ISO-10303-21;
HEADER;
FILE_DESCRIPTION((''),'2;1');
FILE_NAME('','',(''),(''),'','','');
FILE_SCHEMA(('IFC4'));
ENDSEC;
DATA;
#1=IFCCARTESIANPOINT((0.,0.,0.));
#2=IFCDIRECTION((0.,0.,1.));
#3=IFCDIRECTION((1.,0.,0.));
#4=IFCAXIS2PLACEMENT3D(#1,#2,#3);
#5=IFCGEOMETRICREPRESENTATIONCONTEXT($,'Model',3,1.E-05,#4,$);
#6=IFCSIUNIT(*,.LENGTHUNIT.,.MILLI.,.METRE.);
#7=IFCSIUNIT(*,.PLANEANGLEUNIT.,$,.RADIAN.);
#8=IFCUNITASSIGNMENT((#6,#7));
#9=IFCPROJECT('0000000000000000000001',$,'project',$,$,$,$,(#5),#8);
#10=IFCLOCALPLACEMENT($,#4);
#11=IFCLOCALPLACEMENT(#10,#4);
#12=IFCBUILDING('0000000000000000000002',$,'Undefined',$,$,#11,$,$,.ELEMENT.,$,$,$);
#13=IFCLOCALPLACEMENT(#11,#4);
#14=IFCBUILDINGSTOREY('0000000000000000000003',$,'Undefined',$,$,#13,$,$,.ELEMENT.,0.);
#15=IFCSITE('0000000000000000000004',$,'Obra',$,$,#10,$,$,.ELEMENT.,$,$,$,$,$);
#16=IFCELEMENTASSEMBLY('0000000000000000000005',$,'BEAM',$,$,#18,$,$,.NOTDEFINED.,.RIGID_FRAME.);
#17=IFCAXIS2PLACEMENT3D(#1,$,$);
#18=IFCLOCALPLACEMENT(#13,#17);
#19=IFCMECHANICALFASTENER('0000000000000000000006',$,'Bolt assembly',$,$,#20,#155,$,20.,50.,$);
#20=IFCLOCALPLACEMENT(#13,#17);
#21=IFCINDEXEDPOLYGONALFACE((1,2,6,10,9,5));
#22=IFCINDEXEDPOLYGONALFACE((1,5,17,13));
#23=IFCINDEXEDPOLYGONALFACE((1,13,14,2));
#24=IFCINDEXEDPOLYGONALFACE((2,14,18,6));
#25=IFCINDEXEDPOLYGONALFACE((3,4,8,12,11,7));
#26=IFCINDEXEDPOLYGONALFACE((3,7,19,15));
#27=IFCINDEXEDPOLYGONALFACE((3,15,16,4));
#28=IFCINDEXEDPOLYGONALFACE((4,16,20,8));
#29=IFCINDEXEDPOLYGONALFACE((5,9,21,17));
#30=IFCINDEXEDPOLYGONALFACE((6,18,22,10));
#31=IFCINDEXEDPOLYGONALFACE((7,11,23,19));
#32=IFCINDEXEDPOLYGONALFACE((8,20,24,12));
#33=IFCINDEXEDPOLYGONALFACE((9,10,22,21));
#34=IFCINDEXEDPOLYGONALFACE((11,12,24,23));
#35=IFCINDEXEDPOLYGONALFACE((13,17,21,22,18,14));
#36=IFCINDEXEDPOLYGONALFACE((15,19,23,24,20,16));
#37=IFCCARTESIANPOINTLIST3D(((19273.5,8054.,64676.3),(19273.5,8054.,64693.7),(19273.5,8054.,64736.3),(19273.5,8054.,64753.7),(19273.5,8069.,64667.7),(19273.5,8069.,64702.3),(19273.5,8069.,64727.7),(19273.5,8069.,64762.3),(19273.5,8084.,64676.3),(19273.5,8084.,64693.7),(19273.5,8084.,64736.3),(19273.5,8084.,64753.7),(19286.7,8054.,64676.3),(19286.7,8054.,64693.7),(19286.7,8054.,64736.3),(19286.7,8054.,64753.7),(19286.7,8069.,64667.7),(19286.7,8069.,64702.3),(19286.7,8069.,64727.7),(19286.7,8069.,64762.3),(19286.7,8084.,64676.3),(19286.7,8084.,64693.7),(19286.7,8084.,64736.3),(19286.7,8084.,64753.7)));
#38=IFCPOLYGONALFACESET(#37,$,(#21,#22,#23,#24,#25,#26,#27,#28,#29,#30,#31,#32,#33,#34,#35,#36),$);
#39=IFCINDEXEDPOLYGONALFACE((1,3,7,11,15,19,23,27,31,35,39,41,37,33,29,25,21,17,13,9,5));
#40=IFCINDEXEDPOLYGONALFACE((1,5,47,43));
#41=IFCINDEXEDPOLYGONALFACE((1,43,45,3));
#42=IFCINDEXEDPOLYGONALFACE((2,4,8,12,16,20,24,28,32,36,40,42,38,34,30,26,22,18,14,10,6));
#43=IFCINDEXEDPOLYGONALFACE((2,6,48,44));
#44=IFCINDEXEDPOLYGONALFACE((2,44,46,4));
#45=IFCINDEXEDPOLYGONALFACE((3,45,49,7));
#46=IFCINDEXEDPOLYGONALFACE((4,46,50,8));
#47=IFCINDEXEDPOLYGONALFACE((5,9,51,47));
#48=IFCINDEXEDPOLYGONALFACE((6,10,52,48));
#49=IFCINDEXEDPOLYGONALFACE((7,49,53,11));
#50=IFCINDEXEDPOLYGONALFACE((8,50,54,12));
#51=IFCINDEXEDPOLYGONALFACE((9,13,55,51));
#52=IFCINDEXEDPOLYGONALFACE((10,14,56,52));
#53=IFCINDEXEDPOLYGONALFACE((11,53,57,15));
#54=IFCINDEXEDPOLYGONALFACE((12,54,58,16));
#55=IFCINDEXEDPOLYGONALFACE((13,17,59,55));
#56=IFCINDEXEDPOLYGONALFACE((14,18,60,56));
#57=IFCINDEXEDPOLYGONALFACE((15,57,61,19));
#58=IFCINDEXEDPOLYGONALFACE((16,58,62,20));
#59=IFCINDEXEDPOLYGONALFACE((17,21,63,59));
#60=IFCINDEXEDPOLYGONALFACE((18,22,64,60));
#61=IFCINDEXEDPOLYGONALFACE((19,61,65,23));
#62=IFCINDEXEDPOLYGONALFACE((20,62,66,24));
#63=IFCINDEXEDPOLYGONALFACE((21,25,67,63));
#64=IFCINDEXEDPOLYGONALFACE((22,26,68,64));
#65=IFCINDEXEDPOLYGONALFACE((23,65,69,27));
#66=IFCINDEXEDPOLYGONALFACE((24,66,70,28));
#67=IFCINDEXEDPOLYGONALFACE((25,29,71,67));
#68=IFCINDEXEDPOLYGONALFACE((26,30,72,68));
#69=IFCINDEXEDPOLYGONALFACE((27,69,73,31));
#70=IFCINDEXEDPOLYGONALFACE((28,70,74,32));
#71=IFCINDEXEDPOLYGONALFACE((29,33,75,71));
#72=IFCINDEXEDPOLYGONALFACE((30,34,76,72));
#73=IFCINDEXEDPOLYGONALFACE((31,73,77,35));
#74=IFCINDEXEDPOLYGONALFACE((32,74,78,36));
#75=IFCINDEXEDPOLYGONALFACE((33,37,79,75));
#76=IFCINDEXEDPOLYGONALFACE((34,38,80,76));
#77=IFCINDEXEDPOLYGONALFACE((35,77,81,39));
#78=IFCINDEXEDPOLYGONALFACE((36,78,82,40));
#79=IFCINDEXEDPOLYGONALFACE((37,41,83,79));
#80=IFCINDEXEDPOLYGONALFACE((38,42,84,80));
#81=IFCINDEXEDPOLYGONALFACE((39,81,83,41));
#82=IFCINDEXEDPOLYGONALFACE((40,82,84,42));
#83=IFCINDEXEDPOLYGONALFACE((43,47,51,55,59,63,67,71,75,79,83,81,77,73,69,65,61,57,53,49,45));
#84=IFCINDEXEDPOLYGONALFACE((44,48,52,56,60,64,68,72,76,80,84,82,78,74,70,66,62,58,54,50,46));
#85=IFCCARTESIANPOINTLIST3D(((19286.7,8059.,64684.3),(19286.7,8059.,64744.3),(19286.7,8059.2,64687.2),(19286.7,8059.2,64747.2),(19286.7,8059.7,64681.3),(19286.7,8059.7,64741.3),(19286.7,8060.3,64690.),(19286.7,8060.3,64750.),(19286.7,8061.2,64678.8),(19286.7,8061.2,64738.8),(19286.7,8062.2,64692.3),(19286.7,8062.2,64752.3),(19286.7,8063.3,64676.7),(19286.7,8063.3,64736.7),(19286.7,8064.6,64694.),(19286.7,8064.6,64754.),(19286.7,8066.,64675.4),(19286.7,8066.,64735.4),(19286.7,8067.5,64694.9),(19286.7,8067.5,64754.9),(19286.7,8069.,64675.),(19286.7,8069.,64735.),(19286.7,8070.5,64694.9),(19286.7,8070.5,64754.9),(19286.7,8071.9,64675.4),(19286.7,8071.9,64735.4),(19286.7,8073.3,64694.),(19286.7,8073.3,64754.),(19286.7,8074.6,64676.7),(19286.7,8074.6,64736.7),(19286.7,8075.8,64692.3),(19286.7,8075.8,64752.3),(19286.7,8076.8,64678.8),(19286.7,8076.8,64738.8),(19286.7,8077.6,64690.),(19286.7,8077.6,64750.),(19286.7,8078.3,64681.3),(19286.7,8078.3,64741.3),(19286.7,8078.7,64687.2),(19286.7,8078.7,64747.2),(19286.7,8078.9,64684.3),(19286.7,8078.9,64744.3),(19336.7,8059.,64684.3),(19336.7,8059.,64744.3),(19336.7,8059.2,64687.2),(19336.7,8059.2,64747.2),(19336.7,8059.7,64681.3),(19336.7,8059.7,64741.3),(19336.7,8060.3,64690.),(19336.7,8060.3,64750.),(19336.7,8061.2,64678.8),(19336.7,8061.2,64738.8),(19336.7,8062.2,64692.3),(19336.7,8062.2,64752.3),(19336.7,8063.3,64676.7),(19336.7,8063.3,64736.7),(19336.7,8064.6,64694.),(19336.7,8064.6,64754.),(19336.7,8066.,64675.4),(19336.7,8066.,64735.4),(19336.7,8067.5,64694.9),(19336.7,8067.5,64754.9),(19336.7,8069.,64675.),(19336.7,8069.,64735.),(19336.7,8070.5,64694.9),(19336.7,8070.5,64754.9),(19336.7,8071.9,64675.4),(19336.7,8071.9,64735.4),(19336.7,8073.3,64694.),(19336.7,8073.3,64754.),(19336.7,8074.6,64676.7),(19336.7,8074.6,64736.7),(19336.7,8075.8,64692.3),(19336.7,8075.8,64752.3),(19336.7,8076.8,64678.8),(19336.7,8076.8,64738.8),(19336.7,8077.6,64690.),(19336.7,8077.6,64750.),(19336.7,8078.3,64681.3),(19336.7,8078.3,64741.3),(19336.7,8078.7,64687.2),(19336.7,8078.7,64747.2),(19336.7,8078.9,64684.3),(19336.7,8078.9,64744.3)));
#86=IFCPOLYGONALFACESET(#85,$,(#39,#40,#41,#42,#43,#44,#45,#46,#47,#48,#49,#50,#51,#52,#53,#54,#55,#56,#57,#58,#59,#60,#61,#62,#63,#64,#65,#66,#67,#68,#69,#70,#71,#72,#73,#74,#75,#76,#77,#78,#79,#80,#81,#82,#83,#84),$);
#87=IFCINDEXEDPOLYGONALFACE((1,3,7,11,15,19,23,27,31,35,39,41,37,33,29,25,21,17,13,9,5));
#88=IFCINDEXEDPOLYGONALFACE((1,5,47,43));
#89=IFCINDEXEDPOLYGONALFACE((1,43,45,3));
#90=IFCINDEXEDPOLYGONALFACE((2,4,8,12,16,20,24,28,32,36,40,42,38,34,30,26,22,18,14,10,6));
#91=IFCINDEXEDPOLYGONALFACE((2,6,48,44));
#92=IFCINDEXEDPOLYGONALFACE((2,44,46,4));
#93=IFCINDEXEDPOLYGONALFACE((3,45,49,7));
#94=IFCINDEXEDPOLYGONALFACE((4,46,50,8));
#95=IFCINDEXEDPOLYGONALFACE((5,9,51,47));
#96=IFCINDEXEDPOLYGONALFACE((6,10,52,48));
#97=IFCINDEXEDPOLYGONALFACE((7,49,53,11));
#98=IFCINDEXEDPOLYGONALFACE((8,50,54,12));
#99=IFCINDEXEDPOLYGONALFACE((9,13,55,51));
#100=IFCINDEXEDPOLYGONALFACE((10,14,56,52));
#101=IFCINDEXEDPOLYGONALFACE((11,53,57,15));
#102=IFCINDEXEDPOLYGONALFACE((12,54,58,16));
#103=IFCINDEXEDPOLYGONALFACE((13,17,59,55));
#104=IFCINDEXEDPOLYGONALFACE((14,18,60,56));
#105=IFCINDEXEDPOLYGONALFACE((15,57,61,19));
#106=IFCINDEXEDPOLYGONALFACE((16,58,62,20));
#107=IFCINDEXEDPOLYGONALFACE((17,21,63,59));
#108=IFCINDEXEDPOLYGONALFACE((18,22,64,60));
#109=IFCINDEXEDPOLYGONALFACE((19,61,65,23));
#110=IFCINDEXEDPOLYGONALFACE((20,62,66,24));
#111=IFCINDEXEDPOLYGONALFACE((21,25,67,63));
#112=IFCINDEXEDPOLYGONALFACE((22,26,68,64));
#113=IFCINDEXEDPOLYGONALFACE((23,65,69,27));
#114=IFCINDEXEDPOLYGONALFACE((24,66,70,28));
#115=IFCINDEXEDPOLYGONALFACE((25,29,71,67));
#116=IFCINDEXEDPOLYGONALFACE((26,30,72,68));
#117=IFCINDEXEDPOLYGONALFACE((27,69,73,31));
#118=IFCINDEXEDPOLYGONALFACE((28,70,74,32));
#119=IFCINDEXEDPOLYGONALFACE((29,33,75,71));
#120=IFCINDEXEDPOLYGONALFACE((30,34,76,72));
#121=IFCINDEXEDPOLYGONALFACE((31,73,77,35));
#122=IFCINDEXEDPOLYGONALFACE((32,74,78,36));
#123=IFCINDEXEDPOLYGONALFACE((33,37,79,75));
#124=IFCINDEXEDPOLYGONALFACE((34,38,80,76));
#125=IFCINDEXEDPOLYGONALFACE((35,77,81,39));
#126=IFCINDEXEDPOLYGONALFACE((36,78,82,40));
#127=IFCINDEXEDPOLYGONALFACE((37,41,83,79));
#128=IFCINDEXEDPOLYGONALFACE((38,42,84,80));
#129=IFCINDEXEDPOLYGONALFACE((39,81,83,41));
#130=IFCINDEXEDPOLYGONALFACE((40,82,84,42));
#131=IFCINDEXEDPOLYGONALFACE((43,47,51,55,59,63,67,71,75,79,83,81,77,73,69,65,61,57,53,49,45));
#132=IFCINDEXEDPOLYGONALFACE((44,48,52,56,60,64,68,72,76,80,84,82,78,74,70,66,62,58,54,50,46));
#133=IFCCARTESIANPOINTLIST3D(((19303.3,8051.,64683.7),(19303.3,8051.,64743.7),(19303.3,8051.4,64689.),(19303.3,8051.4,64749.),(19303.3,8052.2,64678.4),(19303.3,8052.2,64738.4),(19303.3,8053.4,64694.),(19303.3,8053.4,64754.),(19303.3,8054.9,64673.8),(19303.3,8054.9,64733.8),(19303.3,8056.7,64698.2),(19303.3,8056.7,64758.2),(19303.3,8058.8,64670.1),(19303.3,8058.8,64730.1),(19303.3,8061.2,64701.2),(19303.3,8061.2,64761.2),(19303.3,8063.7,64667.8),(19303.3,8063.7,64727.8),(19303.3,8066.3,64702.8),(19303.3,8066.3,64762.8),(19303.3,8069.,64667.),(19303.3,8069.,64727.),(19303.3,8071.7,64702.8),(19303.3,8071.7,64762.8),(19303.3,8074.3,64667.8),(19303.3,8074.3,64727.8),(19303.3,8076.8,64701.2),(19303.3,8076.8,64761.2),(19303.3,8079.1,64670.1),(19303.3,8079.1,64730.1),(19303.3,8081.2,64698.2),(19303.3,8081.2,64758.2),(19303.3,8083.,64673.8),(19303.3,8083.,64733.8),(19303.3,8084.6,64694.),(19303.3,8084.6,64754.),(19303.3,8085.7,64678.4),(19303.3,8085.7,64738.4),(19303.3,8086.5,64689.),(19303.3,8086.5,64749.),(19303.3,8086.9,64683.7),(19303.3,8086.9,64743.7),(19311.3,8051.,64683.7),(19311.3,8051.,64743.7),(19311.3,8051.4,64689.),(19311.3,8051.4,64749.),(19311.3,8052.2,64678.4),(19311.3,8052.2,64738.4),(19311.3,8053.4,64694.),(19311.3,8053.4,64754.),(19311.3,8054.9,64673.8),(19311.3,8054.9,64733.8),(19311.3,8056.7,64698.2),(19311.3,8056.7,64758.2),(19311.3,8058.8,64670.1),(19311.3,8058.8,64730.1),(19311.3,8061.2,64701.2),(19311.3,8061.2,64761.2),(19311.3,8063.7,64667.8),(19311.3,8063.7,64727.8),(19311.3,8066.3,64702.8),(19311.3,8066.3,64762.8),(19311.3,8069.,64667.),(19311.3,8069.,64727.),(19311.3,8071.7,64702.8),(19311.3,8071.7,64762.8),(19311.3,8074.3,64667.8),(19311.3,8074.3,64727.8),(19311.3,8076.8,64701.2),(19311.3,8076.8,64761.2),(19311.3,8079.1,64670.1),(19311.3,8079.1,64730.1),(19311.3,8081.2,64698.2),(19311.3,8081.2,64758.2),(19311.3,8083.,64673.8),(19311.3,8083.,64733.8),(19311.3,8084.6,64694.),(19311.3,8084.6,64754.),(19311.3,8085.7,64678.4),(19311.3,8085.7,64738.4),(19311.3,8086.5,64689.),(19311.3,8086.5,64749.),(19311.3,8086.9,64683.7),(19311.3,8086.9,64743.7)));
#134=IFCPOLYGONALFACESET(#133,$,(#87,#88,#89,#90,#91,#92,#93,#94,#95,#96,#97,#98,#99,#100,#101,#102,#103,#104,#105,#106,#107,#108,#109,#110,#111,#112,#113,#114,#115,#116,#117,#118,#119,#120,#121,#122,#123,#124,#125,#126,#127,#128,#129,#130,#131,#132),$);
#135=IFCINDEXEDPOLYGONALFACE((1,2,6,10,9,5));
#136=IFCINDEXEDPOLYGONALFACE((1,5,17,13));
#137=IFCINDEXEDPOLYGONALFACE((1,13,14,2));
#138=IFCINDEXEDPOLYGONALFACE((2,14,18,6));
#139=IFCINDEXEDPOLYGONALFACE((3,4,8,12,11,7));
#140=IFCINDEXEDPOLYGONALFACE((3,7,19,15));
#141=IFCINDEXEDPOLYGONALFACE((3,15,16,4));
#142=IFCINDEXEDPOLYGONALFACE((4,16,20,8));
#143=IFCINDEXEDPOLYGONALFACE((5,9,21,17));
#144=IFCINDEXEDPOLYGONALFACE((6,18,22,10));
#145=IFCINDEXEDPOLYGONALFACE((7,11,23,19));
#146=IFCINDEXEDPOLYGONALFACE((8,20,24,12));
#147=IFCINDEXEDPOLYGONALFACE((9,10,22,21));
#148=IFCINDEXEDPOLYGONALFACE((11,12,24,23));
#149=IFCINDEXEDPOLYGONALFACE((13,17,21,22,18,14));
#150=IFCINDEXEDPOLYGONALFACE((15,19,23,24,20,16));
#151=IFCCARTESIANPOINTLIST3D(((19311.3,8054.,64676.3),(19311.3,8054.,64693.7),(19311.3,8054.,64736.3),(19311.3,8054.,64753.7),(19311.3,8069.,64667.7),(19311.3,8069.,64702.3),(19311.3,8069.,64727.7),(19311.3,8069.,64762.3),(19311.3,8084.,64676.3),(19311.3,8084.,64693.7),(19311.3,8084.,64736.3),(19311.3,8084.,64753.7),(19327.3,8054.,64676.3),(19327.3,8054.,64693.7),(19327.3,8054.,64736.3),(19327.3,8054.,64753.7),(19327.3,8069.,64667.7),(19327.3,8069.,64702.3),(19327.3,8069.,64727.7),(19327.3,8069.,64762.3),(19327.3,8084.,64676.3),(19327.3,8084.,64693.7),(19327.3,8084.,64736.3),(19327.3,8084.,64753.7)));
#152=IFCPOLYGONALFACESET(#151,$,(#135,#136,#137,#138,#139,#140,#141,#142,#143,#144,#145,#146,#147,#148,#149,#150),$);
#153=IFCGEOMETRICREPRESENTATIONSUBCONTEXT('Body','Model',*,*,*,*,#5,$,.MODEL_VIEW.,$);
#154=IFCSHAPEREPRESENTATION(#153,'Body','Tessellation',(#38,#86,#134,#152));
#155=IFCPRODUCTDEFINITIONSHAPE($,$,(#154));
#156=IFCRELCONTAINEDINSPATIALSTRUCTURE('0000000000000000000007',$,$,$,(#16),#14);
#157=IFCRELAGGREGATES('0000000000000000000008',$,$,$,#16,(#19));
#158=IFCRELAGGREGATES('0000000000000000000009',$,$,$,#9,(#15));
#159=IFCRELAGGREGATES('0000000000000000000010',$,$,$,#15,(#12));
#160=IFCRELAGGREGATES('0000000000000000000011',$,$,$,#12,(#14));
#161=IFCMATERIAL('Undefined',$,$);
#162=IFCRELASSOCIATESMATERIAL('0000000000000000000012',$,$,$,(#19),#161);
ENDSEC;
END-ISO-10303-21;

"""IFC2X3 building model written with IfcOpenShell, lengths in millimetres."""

from ifc_helpers import new_model, si_unit, frame, origin_with_axes, origin_2d_with_axis, place, context, subcontext, project, spatial, polyline, circle, outline, extrude, source, transform, mapped, material, element, aggregate, save


model = new_model("IFC2X3")

# Units and contexts
model_context = context("Model", 3, precision=1e-05, world=origin_with_axes())
body_context = subcontext(model_context, "Body", "Model", "MODEL_VIEW")
ifc_project = project(units=[si_unit("LENGTHUNIT", "METRE", prefix="MILLI"), si_unit("PLANEANGLEUNIT", "RADIAN")], contexts=[model_context])

# Site, building, storey
site_placement = place(None, origin_with_axes())
site = spatial("IfcSite", under=ifc_project, at=site_placement, Name="Obra", CompositionType="ELEMENT")
building_placement = place(site_placement, origin_with_axes())
building = spatial("IfcBuilding", under=site, at=building_placement, Name="Undefined", CompositionType="ELEMENT")
storey_placement = place(building_placement, origin_with_axes())
storey = spatial("IfcBuildingStorey", under=building, at=storey_placement, Name="Undefined", CompositionType="ELEMENT", Elevation=0.0)

# Shared definitions
ifc_material = material(Name="Undefined")
shared_shape_1 = source(origin_with_axes(), body_context, "Body", "SweptSolid", [
    extrude(outline(polyline([(17.3, 0.0), (8.7, 15.0), (-8.7, 15.0), (-17.3, 0.0), (-8.7, -15.0), (8.7, -15.0), (17.3, 0.0)])), frame((0.0, -26.5, 0.0), z_axis=(0.0, 1.0, 0.0), x_axis=(1.0, 0.0, 0.0)), (0.0, 0.0, 1.0), 13.2),
    extrude(circle(Radius=10.0, at=origin_2d_with_axis()), frame((0.0, -13.3, 0.0), z_axis=(0.0, 1.0, 0.0), x_axis=(1.0, 0.0, 0.0)), (0.0, 0.0, 1.0), 50.0),
    extrude(circle(Radius=18.0, at=origin_2d_with_axis()), frame((0.0, 3.3, 0.0), z_axis=(0.0, 1.0, 0.0), x_axis=(1.0, 0.0, 0.0)), (0.0, 0.0, 1.0), 8.0),
    extrude(outline(polyline([(17.3, 0.0), (8.7, 15.0), (-8.7, 15.0), (-17.3, 0.0), (-8.7, -15.0), (8.7, -15.0), (17.3, 0.0)])), frame((0.0, 11.3, 0.0), z_axis=(0.0, 1.0, 0.0), x_axis=(1.0, 0.0, 0.0)), (0.0, 0.0, 1.0), 16.0),
])

# Element assembly, mechanical fastener
assembly_1_placement = place(storey_placement, origin_with_axes())
assembly_1 = element("IfcElementAssembly", 1, at=assembly_1_placement, inside=storey, Name="BEAM", AssemblyPlace="NOTDEFINED", PredefinedType="RIGID_FRAME")
mechanical_fastener_1_placement = place(assembly_1_placement, frame((19300.0, 8109.0, 64850.0), z_axis=(0.0, -1.0, 0.0), x_axis=(0.0, 0.0, -1.0)))
mechanical_fastener_1 = element("IfcMechanicalFastener", 2, at=mechanical_fastener_1_placement, material=ifc_material, Name="Bolt assembly", NominalDiameter=20.0, NominalLength=50.0, context=body_context, shape_type="MappedRepresentation", body=[
    mapped(shared_shape_1, transform((105.0, 0.0, 40.0))),
    mapped(shared_shape_1, transform((165.0, 0.0, 40.0))),
])

aggregate(assembly_1, [mechanical_fastener_1])

save(model, "model.ifc")
